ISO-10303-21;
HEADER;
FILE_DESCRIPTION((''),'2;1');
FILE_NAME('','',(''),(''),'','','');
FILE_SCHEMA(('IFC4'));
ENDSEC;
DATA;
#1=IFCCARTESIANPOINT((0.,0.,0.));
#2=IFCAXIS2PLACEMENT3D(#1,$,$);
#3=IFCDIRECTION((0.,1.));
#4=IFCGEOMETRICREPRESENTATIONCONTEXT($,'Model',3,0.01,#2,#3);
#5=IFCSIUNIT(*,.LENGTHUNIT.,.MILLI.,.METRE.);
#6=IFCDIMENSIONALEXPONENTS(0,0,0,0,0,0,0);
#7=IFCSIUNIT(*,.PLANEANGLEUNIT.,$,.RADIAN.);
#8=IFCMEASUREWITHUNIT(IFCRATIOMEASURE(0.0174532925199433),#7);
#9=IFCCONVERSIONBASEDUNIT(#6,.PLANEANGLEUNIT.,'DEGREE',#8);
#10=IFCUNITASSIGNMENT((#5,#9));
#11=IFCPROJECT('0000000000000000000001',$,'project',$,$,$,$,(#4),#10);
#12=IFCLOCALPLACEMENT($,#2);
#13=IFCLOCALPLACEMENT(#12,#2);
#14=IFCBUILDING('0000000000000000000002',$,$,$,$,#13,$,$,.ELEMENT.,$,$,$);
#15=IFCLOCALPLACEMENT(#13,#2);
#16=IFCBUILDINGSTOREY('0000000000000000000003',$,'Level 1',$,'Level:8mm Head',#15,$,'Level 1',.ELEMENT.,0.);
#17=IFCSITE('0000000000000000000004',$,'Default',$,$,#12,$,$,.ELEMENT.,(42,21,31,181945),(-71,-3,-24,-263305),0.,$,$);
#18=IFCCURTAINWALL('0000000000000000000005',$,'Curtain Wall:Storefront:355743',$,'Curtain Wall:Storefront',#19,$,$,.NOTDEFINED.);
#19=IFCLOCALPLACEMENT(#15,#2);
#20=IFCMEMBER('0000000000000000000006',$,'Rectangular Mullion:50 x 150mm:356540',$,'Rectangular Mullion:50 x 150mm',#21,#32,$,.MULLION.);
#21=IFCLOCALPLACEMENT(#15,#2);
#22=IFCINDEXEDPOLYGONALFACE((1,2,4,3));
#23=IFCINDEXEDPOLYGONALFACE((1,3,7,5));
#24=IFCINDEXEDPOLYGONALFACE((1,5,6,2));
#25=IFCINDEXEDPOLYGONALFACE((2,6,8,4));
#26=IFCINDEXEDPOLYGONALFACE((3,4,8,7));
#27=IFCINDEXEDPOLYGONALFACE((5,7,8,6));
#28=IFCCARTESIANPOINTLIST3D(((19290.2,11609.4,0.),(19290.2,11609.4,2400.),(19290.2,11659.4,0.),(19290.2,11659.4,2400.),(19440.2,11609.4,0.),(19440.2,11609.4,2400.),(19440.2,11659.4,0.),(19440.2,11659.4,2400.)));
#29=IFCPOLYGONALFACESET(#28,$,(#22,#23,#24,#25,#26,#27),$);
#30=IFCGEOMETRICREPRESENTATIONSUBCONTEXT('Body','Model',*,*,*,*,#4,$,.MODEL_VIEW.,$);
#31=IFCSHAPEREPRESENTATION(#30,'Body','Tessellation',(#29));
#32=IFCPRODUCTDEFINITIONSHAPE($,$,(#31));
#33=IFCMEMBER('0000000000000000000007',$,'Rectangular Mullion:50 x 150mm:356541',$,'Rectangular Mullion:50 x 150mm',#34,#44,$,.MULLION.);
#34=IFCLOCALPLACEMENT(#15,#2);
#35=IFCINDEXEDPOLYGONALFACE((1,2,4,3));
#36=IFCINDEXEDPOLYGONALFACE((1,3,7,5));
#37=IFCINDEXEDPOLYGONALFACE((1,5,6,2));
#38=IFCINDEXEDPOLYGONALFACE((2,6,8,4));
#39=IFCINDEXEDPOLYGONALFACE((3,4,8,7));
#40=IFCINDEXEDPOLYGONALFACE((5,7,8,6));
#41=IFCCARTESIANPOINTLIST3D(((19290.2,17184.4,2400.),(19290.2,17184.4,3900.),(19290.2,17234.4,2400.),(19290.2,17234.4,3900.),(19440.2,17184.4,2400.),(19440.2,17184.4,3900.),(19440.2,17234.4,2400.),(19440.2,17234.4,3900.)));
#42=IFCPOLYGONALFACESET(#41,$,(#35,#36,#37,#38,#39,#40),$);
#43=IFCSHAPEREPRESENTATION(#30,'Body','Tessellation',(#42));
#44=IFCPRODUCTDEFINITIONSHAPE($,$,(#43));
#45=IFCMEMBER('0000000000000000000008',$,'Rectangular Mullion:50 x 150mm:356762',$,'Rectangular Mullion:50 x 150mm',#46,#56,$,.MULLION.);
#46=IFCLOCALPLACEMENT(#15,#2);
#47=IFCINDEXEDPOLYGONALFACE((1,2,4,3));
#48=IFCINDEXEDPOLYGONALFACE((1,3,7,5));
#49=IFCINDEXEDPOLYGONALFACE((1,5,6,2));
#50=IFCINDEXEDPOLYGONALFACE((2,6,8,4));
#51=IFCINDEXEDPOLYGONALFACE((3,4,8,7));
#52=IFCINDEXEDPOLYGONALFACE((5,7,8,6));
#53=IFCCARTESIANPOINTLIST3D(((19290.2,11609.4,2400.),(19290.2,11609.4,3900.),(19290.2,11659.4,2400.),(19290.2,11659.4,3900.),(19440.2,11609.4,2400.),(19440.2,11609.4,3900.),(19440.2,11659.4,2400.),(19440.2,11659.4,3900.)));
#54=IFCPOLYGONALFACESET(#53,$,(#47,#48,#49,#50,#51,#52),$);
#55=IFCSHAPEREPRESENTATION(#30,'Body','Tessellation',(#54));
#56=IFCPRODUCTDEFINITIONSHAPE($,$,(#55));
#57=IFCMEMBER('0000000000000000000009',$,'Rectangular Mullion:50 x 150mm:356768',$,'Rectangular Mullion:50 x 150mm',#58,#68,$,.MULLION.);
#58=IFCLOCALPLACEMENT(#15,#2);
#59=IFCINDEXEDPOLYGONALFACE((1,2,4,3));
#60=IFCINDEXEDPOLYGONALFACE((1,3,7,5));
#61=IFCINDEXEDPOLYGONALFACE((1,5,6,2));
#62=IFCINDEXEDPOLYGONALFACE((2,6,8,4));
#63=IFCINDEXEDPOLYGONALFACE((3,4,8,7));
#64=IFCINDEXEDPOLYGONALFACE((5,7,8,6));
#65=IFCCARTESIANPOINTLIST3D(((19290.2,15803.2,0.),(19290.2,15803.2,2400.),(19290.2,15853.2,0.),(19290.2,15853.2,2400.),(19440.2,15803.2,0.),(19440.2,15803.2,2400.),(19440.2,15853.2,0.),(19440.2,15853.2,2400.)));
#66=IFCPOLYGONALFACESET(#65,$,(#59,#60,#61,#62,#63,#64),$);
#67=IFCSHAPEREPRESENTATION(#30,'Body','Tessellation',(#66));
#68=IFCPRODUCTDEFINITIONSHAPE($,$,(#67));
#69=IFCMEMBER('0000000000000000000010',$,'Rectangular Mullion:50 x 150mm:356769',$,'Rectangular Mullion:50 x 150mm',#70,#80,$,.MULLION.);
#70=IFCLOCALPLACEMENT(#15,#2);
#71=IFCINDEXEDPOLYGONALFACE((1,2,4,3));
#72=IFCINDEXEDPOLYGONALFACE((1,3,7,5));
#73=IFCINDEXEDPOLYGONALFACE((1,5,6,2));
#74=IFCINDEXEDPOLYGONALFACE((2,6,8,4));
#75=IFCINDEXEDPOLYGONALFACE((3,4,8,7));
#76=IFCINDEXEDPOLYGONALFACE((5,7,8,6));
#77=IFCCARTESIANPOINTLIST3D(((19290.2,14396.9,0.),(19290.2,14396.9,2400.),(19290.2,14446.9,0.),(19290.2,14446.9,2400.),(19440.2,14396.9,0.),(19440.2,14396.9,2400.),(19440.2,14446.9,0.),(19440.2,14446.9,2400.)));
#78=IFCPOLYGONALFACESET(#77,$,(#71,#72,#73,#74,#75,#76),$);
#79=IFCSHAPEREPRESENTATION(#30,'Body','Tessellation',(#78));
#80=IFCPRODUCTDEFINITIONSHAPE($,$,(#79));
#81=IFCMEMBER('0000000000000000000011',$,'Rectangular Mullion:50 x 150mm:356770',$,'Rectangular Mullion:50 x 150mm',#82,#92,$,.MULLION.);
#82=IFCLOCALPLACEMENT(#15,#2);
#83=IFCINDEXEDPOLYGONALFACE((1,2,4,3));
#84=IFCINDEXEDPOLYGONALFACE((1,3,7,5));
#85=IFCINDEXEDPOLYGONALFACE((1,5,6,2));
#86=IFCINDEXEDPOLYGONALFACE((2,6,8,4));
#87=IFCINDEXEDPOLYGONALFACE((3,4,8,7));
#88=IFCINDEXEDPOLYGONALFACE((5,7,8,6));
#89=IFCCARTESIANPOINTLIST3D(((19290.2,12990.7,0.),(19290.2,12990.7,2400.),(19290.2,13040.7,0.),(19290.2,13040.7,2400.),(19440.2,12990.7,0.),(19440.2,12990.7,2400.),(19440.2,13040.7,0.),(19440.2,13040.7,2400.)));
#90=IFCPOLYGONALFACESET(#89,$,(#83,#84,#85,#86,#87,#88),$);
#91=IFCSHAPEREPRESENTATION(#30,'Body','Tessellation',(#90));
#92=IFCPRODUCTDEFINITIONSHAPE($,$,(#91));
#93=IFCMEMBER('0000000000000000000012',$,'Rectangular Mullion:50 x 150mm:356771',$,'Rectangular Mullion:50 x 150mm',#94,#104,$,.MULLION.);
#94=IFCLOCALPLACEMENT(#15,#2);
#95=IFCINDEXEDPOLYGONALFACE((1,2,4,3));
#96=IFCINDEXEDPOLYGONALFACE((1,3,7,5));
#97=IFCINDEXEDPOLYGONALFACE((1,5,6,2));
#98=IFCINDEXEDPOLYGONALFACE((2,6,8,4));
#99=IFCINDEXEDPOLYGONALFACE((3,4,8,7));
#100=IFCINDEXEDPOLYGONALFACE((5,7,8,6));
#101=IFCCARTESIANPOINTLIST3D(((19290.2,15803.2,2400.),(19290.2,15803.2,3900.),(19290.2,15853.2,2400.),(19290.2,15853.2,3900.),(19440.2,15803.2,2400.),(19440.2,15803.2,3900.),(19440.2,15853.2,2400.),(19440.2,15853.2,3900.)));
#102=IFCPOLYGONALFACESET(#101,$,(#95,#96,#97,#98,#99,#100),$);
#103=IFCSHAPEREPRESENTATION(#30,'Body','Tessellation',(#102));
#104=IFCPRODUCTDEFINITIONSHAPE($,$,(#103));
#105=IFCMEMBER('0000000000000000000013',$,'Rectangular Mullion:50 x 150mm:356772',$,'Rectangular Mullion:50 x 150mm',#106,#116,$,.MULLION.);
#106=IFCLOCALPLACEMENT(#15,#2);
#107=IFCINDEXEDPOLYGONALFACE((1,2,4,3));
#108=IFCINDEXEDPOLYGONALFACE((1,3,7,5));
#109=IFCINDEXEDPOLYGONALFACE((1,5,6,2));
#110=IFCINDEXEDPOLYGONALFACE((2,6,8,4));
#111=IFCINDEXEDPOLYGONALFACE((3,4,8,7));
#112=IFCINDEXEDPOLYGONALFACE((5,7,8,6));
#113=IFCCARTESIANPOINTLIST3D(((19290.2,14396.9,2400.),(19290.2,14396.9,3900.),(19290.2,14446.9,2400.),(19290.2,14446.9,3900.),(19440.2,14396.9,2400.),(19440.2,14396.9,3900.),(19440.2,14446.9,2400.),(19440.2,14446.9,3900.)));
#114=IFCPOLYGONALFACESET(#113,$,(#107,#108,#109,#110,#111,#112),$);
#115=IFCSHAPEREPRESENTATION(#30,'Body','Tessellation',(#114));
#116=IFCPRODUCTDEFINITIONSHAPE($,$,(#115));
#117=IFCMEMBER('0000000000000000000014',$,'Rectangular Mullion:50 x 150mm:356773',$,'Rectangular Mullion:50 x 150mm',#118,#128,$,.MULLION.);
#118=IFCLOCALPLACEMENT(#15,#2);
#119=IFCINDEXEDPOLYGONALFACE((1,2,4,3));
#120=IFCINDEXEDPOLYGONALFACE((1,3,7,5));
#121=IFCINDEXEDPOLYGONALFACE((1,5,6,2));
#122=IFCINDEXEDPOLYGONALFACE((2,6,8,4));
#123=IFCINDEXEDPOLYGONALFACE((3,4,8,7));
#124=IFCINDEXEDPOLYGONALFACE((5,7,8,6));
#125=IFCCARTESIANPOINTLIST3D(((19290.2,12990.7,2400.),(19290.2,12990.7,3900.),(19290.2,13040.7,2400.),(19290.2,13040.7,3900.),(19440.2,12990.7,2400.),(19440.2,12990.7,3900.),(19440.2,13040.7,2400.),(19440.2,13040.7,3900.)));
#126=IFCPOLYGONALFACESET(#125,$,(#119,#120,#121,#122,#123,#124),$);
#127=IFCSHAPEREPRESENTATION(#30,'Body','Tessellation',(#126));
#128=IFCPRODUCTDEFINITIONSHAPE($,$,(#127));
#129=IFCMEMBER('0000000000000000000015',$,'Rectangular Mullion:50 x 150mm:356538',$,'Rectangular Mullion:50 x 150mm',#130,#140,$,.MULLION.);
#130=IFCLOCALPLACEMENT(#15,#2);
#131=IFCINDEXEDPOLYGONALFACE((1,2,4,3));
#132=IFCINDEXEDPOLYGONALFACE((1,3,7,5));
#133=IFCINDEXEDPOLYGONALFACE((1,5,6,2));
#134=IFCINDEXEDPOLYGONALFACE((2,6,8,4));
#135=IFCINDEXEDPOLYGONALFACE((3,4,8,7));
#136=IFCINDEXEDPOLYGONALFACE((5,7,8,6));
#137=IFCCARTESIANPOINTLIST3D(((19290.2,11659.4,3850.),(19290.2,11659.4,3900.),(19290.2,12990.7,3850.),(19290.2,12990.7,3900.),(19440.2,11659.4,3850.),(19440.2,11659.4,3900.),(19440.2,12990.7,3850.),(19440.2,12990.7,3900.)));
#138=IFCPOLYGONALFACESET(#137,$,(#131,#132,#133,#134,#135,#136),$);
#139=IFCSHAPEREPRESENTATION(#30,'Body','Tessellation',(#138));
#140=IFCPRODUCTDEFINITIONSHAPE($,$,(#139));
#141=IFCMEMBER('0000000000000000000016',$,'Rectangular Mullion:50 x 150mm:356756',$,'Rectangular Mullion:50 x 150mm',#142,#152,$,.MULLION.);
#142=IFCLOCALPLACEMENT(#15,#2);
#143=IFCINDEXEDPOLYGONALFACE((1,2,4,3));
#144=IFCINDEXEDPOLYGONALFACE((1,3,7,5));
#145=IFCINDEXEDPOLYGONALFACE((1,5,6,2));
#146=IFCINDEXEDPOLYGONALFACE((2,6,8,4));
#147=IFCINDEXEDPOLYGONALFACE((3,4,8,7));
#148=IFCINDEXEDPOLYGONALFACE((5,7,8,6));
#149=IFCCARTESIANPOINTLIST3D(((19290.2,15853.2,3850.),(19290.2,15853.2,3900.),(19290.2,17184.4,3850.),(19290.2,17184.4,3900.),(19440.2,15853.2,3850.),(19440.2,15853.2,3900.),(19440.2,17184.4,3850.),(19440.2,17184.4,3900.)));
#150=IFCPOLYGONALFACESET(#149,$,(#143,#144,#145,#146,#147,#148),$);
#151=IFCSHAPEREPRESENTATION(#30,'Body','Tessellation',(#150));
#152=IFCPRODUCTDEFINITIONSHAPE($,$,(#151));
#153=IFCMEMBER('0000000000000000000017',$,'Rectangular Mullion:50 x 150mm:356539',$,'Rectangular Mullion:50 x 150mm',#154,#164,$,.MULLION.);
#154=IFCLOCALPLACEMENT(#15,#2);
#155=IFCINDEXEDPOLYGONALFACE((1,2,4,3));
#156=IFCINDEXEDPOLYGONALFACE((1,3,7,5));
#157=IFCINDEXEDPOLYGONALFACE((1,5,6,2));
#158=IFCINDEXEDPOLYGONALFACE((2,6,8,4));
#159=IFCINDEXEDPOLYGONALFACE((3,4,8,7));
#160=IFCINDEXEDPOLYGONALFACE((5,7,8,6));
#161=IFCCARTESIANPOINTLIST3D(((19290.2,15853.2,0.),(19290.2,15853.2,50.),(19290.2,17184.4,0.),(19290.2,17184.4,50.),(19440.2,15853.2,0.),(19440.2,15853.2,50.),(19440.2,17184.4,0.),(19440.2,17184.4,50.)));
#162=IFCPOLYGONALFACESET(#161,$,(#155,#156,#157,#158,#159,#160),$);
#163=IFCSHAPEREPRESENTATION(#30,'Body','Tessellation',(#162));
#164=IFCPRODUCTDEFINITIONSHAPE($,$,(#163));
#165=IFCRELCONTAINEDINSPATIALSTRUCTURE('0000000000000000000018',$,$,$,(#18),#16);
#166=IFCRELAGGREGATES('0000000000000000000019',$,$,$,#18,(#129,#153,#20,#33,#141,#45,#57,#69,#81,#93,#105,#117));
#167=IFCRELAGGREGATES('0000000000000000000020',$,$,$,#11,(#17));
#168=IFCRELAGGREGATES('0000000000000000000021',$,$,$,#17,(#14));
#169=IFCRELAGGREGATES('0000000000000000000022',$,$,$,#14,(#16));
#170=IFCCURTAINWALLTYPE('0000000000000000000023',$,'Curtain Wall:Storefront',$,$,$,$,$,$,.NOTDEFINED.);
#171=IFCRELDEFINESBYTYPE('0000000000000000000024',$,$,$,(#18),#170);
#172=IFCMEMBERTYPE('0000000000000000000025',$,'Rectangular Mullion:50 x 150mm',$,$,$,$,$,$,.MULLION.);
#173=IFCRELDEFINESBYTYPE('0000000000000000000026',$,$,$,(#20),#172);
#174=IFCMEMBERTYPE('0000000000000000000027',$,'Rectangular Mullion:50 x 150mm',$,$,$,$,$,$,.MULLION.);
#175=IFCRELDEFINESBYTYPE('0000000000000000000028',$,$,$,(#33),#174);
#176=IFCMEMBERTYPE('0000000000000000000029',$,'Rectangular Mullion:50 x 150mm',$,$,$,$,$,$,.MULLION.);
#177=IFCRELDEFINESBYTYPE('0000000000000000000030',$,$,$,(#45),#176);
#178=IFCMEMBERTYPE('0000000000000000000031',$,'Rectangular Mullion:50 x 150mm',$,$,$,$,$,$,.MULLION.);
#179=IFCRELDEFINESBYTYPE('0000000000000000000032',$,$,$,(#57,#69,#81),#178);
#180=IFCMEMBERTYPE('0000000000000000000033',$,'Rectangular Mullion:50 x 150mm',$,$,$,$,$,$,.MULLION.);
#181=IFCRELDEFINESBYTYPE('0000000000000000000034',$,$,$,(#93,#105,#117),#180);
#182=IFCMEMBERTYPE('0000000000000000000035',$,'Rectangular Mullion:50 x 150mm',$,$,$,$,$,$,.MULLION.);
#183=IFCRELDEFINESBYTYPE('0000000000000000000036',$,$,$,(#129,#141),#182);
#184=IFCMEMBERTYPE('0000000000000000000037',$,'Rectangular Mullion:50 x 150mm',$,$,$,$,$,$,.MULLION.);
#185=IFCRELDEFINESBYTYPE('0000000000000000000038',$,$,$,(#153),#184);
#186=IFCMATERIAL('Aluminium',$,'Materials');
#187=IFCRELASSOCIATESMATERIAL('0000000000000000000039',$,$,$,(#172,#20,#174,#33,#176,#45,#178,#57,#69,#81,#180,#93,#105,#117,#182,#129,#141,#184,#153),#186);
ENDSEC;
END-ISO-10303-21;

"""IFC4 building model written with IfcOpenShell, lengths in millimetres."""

from ifc_helpers import new_model, entity, si_unit, converted_unit, direction, frame, origin, place, context, subcontext, project, spatial, indexed_curve, outline, extrude, source, transform, mapped, material, type_object, type_shapes, element, aggregate, save


model = new_model("IFC4")

# Units and contexts
model_context = context("Model", 3, precision=0.01, world=origin(), true_north=direction((0.0, 1.0)))
body_context = subcontext(model_context, "Body", "Model", "MODEL_VIEW")
ifc_project = project(units=[si_unit("LENGTHUNIT", "METRE", prefix="MILLI"), converted_unit("PLANEANGLEUNIT", "DEGREE", entity("IfcRatioMeasure", 0.0174532925199433), si_unit("PLANEANGLEUNIT", "RADIAN"), dimensions=[0, 0, 0, 0, 0, 0, 0])], contexts=[model_context])

# Site, building, storey
site_placement = place(None, origin())
site = spatial("IfcSite", under=ifc_project, at=site_placement, Name="Default", CompositionType="ELEMENT", RefLatitude=(42, 21, 31, 181945), RefLongitude=(-71, -3, -24, -263305), RefElevation=0.0)
building_placement = place(site_placement, origin())
building = spatial("IfcBuilding", under=site, at=building_placement, CompositionType="ELEMENT")
storey_placement = place(building_placement, origin())
storey = spatial("IfcBuildingStorey", under=building, at=storey_placement, Name="Level 1", ObjectType="Level:8mm Head", LongName="Level 1", CompositionType="ELEMENT", Elevation=0.0)

# Curtain wall, members
curtain_wall_type = type_object("IfcCurtainWallType", Name="Curtain Wall:Storefront", PredefinedType="NOTDEFINED")
curtain_wall_placement = place(storey_placement, origin())
curtain_wall = element("IfcCurtainWall", 1, at=curtain_wall_placement, inside=storey, type_object=curtain_wall_type, Name="Curtain Wall:Storefront:355743", ObjectType="Curtain Wall:Storefront", PredefinedType="NOTDEFINED")
ifc_material_1 = material(Name="Aluminium", Category="Materials")
member_type_1 = type_object("IfcMemberType", Name="Rectangular Mullion:50 x 150mm", PredefinedType="MULLION", material=ifc_material_1)
shared_shape_1 = source(origin(), body_context, "Body", "SweptSolid", [
    extrude(outline(indexed_curve([(-75.0, -25.0), (75.0, -25.0), (75.0, 25.0), (-75.0, 25.0), (-75.0, -25.0)], self_intersect=False)), frame((-25.0, 0.0, -2400.0), z_axis=(0.0, 0.0, 1.0), x_axis=(0.0, -1.0, 0.0)), (0.0, 0.0, 1.0), 2400.0),
])
type_shapes(member_type_1, [shared_shape_1])
member_1_placement = place(storey_placement, frame((19365.2, 11609.4, 0.0), z_axis=(0.0, 0.0, -1.0), x_axis=(0.0, -1.0, 0.0)))
member_1 = element("IfcMember", 2, at=member_1_placement, type_object=member_type_1, material=ifc_material_1, Name="Rectangular Mullion:50 x 150mm:356540", ObjectType="Rectangular Mullion:50 x 150mm", PredefinedType="MULLION", context=body_context, shape_type="MappedRepresentation", body=[
    mapped(shared_shape_1, transform((0.0, 0.0, 0.0), scale=1.0)),
])
member_type_2 = type_object("IfcMemberType", Name="Rectangular Mullion:50 x 150mm", PredefinedType="MULLION", material=ifc_material_1)
shared_shape_2 = source(origin(), body_context, "Body", "SweptSolid", [
    extrude(outline(indexed_curve([(-75.0, -25.0), (75.0, -25.0), (75.0, 25.0), (-75.0, 25.0), (-75.0, -25.0)], self_intersect=False)), frame((-25.0, 0.0, -1500.0), z_axis=(0.0, 0.0, 1.0), x_axis=(0.0, -1.0, 0.0)), (0.0, 0.0, 1.0), 1500.0),
])
type_shapes(member_type_2, [shared_shape_2])
member_2_placement = place(storey_placement, frame((19365.2, 17234.4, 3900.0), z_axis=(0.0, 0.0, 1.0), x_axis=(0.0, 1.0, 0.0)))
member_2 = element("IfcMember", 3, at=member_2_placement, type_object=member_type_2, material=ifc_material_1, Name="Rectangular Mullion:50 x 150mm:356541", ObjectType="Rectangular Mullion:50 x 150mm", PredefinedType="MULLION", context=body_context, shape_type="MappedRepresentation", body=[
    mapped(shared_shape_2, transform((0.0, 0.0, 0.0), scale=1.0)),
])
member_type_3 = type_object("IfcMemberType", Name="Rectangular Mullion:50 x 150mm", PredefinedType="MULLION", material=ifc_material_1)
shared_shape_3 = source(origin(), body_context, "Body", "SweptSolid", [
    extrude(outline(indexed_curve([(-75.0, -25.0), (75.0, -25.0), (75.0, 25.0), (-75.0, 25.0), (-75.0, -25.0)], self_intersect=False)), frame((-25.0, 0.0, -1500.0), z_axis=(0.0, 0.0, 1.0), x_axis=(0.0, -1.0, 0.0)), (0.0, 0.0, 1.0), 1500.0),
])
type_shapes(member_type_3, [shared_shape_3])
member_3_placement = place(storey_placement, frame((19365.2, 11609.4, 2400.0), z_axis=(0.0, 0.0, -1.0), x_axis=(0.0, -1.0, 0.0)))
member_3 = element("IfcMember", 4, at=member_3_placement, type_object=member_type_3, material=ifc_material_1, Name="Rectangular Mullion:50 x 150mm:356762", ObjectType="Rectangular Mullion:50 x 150mm", PredefinedType="MULLION", context=body_context, shape_type="MappedRepresentation", body=[
    mapped(shared_shape_3, transform((0.0, 0.0, 0.0), scale=1.0)),
])
member_type_4 = type_object("IfcMemberType", Name="Rectangular Mullion:50 x 150mm", PredefinedType="MULLION", material=ifc_material_1)
shared_shape_4 = source(origin(), body_context, "Body", "SweptSolid", [
    extrude(outline(indexed_curve([(-75.0, -25.0), (75.0, -25.0), (75.0, 25.0), (-75.0, 25.0), (-75.0, -25.0)], self_intersect=False)), frame((0.0, 0.0, -2400.0), z_axis=(0.0, 0.0, 1.0), x_axis=(0.0, -1.0, 0.0)), (0.0, 0.0, 1.0), 2400.0),
])
type_shapes(member_type_4, [shared_shape_4])
member_4_placement = place(storey_placement, frame((19365.2, 15828.2, 0.0), z_axis=(0.0, 0.0, -1.0), x_axis=(0.0, -1.0, 0.0)))
member_4 = element("IfcMember", 5, at=member_4_placement, type_object=member_type_4, material=ifc_material_1, Name="Rectangular Mullion:50 x 150mm:356768", ObjectType="Rectangular Mullion:50 x 150mm", PredefinedType="MULLION", context=body_context, shape_type="MappedRepresentation", body=[
    mapped(shared_shape_4, transform((0.0, 0.0, 0.0), scale=1.0)),
])
member_5_placement = place(storey_placement, frame((19365.2, 14421.9, 0.0), z_axis=(0.0, 0.0, -1.0), x_axis=(0.0, -1.0, 0.0)))
member_5 = element("IfcMember", 6, at=member_5_placement, type_object=member_type_4, material=ifc_material_1, Name="Rectangular Mullion:50 x 150mm:356769", ObjectType="Rectangular Mullion:50 x 150mm", PredefinedType="MULLION", context=body_context, shape_type="MappedRepresentation", body=[
    mapped(shared_shape_4, transform((0.0, 0.0, 0.0), scale=1.0)),
])
member_6_placement = place(storey_placement, frame((19365.2, 13015.7, 0.0), z_axis=(0.0, 0.0, -1.0), x_axis=(0.0, -1.0, 0.0)))
member_6 = element("IfcMember", 7, at=member_6_placement, type_object=member_type_4, material=ifc_material_1, Name="Rectangular Mullion:50 x 150mm:356770", ObjectType="Rectangular Mullion:50 x 150mm", PredefinedType="MULLION", context=body_context, shape_type="MappedRepresentation", body=[
    mapped(shared_shape_4, transform((0.0, 0.0, 0.0), scale=1.0)),
])
member_type_5 = type_object("IfcMemberType", Name="Rectangular Mullion:50 x 150mm", PredefinedType="MULLION", material=ifc_material_1)
shared_shape_5 = source(origin(), body_context, "Body", "SweptSolid", [
    extrude(outline(indexed_curve([(-75.0, -25.0), (75.0, -25.0), (75.0, 25.0), (-75.0, 25.0), (-75.0, -25.0)], self_intersect=False)), frame((0.0, 0.0, -1500.0), z_axis=(0.0, 0.0, 1.0), x_axis=(0.0, -1.0, 0.0)), (0.0, 0.0, 1.0), 1500.0),
])
type_shapes(member_type_5, [shared_shape_5])
member_7_placement = place(storey_placement, frame((19365.2, 15828.2, 2400.0), z_axis=(0.0, 0.0, -1.0), x_axis=(0.0, -1.0, 0.0)))
member_7 = element("IfcMember", 8, at=member_7_placement, type_object=member_type_5, material=ifc_material_1, Name="Rectangular Mullion:50 x 150mm:356771", ObjectType="Rectangular Mullion:50 x 150mm", PredefinedType="MULLION", context=body_context, shape_type="MappedRepresentation", body=[
    mapped(shared_shape_5, transform((0.0, 0.0, 0.0), scale=1.0)),
])
member_8_placement = place(storey_placement, frame((19365.2, 14421.9, 2400.0), z_axis=(0.0, 0.0, -1.0), x_axis=(0.0, -1.0, 0.0)))
member_8 = element("IfcMember", 9, at=member_8_placement, type_object=member_type_5, material=ifc_material_1, Name="Rectangular Mullion:50 x 150mm:356772", ObjectType="Rectangular Mullion:50 x 150mm", PredefinedType="MULLION", context=body_context, shape_type="MappedRepresentation", body=[
    mapped(shared_shape_5, transform((0.0, 0.0, 0.0), scale=1.0)),
])
member_9_placement = place(storey_placement, frame((19365.2, 13015.7, 2400.0), z_axis=(0.0, 0.0, -1.0), x_axis=(0.0, -1.0, 0.0)))
member_9 = element("IfcMember", 10, at=member_9_placement, type_object=member_type_5, material=ifc_material_1, Name="Rectangular Mullion:50 x 150mm:356773", ObjectType="Rectangular Mullion:50 x 150mm", PredefinedType="MULLION", context=body_context, shape_type="MappedRepresentation", body=[
    mapped(shared_shape_5, transform((0.0, 0.0, 0.0), scale=1.0)),
])
member_type_6 = type_object("IfcMemberType", Name="Rectangular Mullion:50 x 150mm", PredefinedType="MULLION", material=ifc_material_1)
shared_shape_6 = source(origin(), body_context, "Body", "SweptSolid", [
    extrude(outline(indexed_curve([(-75.0, -25.0), (75.0, -25.0), (75.0, 25.0), (-75.0, 25.0), (-75.0, -25.0)], self_intersect=False)), frame((-25.0, 0.0, -1331.3), z_axis=(0.0, 0.0, 1.0), x_axis=(0.0, -1.0, 0.0)), (0.0, 0.0, 1.0), 1331.3),
])
type_shapes(member_type_6, [shared_shape_6])
member_10_placement = place(storey_placement, frame((19365.2, 11659.4, 3900.0), z_axis=(0.0, -1.0, 0.0), x_axis=(0.0, 0.0, 1.0)))
member_10 = element("IfcMember", 11, at=member_10_placement, type_object=member_type_6, material=ifc_material_1, Name="Rectangular Mullion:50 x 150mm:356538", ObjectType="Rectangular Mullion:50 x 150mm", PredefinedType="MULLION", context=body_context, shape_type="MappedRepresentation", body=[
    mapped(shared_shape_6, transform((0.0, 0.0, 0.0), scale=1.0)),
])
member_11_placement = place(storey_placement, frame((19365.2, 15853.2, 3900.0), z_axis=(0.0, -1.0, 0.0), x_axis=(0.0, 0.0, 1.0)))
member_11 = element("IfcMember", 12, at=member_11_placement, type_object=member_type_6, material=ifc_material_1, Name="Rectangular Mullion:50 x 150mm:356756", ObjectType="Rectangular Mullion:50 x 150mm", PredefinedType="MULLION", context=body_context, shape_type="MappedRepresentation", body=[
    mapped(shared_shape_6, transform((0.0, 0.0, 0.0), scale=1.0)),
])
member_type_7 = type_object("IfcMemberType", Name="Rectangular Mullion:50 x 150mm", PredefinedType="MULLION", material=ifc_material_1)
shared_shape_7 = source(origin(), body_context, "Body", "SweptSolid", [
    extrude(outline(indexed_curve([(-75.0, -25.0), (75.0, -25.0), (75.0, 25.0), (-75.0, 25.0), (-75.0, -25.0)], self_intersect=False)), frame((-25.0, 0.0, -1331.3), z_axis=(0.0, 0.0, 1.0), x_axis=(0.0, -1.0, 0.0)), (0.0, 0.0, 1.0), 1331.3),
])
type_shapes(member_type_7, [shared_shape_7])
member_12_placement = place(storey_placement, frame((19365.2, 17184.4, 0.0), z_axis=(0.0, 1.0, 0.0), x_axis=(0.0, 0.0, -1.0)))
member_12 = element("IfcMember", 13, at=member_12_placement, type_object=member_type_7, material=ifc_material_1, Name="Rectangular Mullion:50 x 150mm:356539", ObjectType="Rectangular Mullion:50 x 150mm", PredefinedType="MULLION", context=body_context, shape_type="MappedRepresentation", body=[
    mapped(shared_shape_7, transform((0.0, 0.0, 0.0), scale=1.0)),
])
aggregate(curtain_wall, [member_10, member_12, member_1, member_2, member_11, member_3, member_4, member_5, member_6, member_7, member_8, member_9])

save(model, "model.ifc")
